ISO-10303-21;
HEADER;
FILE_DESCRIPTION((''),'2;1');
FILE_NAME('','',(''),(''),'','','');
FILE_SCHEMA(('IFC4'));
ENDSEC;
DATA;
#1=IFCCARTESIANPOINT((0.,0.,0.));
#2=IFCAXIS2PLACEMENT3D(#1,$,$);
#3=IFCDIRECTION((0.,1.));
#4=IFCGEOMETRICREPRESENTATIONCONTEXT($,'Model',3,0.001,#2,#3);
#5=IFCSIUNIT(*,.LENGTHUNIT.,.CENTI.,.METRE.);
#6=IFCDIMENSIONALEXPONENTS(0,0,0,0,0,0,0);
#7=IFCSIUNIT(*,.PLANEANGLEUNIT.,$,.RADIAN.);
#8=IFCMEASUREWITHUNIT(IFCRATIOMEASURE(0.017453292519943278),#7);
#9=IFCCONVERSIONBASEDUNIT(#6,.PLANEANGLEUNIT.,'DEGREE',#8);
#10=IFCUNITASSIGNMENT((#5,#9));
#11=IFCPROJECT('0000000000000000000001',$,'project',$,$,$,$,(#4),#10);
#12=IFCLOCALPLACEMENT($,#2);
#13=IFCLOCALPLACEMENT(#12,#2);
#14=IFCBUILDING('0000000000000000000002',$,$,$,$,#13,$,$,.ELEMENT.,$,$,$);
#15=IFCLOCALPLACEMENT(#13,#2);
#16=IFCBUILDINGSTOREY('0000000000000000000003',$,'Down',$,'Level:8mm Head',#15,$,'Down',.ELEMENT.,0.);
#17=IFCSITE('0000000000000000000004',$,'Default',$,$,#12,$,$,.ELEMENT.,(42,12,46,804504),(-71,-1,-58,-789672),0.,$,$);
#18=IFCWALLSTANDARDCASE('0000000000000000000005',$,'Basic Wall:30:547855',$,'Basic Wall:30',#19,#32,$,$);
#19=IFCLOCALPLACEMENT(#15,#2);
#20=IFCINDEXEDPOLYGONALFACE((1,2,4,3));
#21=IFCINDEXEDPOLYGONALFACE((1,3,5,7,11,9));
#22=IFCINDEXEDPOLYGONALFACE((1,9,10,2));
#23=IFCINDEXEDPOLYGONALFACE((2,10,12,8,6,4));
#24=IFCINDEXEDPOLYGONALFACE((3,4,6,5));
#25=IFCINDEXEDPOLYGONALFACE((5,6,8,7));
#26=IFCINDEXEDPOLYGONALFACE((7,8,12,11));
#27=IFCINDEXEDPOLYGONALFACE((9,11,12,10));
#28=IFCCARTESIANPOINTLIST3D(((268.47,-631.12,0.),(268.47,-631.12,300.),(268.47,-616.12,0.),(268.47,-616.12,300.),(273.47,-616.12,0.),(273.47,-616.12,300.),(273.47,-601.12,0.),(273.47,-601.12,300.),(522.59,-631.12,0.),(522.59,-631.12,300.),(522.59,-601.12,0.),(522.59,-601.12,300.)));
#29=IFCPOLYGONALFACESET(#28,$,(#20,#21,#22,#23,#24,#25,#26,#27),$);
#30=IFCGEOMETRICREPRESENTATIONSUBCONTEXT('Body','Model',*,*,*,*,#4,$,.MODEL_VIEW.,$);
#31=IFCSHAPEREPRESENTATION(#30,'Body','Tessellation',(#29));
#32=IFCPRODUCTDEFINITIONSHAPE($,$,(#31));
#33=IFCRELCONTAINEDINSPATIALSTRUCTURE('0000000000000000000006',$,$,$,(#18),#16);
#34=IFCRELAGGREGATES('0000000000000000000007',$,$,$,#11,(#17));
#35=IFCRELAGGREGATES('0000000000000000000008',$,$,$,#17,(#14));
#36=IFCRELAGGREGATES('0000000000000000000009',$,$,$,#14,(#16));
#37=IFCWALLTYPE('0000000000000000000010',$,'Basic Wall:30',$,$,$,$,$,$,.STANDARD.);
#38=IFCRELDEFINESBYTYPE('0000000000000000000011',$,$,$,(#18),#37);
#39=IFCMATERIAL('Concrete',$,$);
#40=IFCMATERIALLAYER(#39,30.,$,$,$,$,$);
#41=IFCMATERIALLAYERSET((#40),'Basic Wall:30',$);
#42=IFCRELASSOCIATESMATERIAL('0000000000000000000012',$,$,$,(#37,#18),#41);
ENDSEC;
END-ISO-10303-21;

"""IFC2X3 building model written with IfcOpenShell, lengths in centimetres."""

from ifc_helpers import new_model, entity, si_unit, converted_unit, direction, frame, origin, place, context, subcontext, project, spatial, polyline, outline, extrude, material, layer, layer_set, layer_usage, type_object, element, save


model = new_model("IFC2X3")

# Units and contexts
model_context = context("Model", 3, precision=0.001, world=origin(), true_north=direction((0.0, 1.0)))
body_context = subcontext(model_context, "Body", "Model", "MODEL_VIEW")
ifc_project = project(units=[si_unit("LENGTHUNIT", "METRE", prefix="CENTI"), converted_unit("PLANEANGLEUNIT", "DEGREE", entity("IfcRatioMeasure", 0.017453292519943278), si_unit("PLANEANGLEUNIT", "RADIAN"), dimensions=[0, 0, 0, 0, 0, 0, 0])], contexts=[model_context])

# Site, building, storey
site_placement = place(None, origin())
site = spatial("IfcSite", under=ifc_project, at=site_placement, Name="Default", CompositionType="ELEMENT", RefLatitude=(42, 12, 46, 804504), RefLongitude=(-71, -1, -58, -789672), RefElevation=0.0)
building_placement = place(site_placement, origin())
building = spatial("IfcBuilding", under=site, at=building_placement, CompositionType="ELEMENT")
storey_placement = place(building_placement, origin())
storey = spatial("IfcBuildingStorey", under=building, at=storey_placement, Name="Down", ObjectType="Level:8mm Head", LongName="Down", CompositionType="ELEMENT", Elevation=0.0)

# Shared definitions
ifc_material = material(Name="Concrete")

# Wall
ifc_layer_1 = layer(ifc_material, 30.0)
ifc_layer_set_1 = layer_set([ifc_layer_1], Name="Basic Wall:30")
ifc_layer_usage_1 = layer_usage(ifc_layer_set_1, "AXIS2", "NEGATIVE", 15.0)
wall_type_1 = type_object("IfcWallType", Name="Basic Wall:30", PredefinedType="STANDARD", material=ifc_layer_set_1)
wall_1_placement = place(storey_placement, frame((522.59, -616.12, 0.0), z_axis=(0.0, 0.0, 1.0), x_axis=(-1.0, 0.0, 0.0)))
element("IfcWallStandardCase", 1, at=wall_1_placement, inside=storey, type_object=wall_type_1, material=ifc_layer_usage_1, Name="Basic Wall:30:547855", ObjectType="Basic Wall:30", context=body_context, shape_type="SweptSolid", body=[
    extrude(outline(polyline([(249.12, -15.0), (249.12, 0.0), (254.12, 0.0), (254.12, 15.0), (0.0, 15.0), (0.0, -15.0), (249.12, -15.0)])), origin(), (0.0, 0.0, 1.0), 300.0),
])

save(model, "model.ifc")
